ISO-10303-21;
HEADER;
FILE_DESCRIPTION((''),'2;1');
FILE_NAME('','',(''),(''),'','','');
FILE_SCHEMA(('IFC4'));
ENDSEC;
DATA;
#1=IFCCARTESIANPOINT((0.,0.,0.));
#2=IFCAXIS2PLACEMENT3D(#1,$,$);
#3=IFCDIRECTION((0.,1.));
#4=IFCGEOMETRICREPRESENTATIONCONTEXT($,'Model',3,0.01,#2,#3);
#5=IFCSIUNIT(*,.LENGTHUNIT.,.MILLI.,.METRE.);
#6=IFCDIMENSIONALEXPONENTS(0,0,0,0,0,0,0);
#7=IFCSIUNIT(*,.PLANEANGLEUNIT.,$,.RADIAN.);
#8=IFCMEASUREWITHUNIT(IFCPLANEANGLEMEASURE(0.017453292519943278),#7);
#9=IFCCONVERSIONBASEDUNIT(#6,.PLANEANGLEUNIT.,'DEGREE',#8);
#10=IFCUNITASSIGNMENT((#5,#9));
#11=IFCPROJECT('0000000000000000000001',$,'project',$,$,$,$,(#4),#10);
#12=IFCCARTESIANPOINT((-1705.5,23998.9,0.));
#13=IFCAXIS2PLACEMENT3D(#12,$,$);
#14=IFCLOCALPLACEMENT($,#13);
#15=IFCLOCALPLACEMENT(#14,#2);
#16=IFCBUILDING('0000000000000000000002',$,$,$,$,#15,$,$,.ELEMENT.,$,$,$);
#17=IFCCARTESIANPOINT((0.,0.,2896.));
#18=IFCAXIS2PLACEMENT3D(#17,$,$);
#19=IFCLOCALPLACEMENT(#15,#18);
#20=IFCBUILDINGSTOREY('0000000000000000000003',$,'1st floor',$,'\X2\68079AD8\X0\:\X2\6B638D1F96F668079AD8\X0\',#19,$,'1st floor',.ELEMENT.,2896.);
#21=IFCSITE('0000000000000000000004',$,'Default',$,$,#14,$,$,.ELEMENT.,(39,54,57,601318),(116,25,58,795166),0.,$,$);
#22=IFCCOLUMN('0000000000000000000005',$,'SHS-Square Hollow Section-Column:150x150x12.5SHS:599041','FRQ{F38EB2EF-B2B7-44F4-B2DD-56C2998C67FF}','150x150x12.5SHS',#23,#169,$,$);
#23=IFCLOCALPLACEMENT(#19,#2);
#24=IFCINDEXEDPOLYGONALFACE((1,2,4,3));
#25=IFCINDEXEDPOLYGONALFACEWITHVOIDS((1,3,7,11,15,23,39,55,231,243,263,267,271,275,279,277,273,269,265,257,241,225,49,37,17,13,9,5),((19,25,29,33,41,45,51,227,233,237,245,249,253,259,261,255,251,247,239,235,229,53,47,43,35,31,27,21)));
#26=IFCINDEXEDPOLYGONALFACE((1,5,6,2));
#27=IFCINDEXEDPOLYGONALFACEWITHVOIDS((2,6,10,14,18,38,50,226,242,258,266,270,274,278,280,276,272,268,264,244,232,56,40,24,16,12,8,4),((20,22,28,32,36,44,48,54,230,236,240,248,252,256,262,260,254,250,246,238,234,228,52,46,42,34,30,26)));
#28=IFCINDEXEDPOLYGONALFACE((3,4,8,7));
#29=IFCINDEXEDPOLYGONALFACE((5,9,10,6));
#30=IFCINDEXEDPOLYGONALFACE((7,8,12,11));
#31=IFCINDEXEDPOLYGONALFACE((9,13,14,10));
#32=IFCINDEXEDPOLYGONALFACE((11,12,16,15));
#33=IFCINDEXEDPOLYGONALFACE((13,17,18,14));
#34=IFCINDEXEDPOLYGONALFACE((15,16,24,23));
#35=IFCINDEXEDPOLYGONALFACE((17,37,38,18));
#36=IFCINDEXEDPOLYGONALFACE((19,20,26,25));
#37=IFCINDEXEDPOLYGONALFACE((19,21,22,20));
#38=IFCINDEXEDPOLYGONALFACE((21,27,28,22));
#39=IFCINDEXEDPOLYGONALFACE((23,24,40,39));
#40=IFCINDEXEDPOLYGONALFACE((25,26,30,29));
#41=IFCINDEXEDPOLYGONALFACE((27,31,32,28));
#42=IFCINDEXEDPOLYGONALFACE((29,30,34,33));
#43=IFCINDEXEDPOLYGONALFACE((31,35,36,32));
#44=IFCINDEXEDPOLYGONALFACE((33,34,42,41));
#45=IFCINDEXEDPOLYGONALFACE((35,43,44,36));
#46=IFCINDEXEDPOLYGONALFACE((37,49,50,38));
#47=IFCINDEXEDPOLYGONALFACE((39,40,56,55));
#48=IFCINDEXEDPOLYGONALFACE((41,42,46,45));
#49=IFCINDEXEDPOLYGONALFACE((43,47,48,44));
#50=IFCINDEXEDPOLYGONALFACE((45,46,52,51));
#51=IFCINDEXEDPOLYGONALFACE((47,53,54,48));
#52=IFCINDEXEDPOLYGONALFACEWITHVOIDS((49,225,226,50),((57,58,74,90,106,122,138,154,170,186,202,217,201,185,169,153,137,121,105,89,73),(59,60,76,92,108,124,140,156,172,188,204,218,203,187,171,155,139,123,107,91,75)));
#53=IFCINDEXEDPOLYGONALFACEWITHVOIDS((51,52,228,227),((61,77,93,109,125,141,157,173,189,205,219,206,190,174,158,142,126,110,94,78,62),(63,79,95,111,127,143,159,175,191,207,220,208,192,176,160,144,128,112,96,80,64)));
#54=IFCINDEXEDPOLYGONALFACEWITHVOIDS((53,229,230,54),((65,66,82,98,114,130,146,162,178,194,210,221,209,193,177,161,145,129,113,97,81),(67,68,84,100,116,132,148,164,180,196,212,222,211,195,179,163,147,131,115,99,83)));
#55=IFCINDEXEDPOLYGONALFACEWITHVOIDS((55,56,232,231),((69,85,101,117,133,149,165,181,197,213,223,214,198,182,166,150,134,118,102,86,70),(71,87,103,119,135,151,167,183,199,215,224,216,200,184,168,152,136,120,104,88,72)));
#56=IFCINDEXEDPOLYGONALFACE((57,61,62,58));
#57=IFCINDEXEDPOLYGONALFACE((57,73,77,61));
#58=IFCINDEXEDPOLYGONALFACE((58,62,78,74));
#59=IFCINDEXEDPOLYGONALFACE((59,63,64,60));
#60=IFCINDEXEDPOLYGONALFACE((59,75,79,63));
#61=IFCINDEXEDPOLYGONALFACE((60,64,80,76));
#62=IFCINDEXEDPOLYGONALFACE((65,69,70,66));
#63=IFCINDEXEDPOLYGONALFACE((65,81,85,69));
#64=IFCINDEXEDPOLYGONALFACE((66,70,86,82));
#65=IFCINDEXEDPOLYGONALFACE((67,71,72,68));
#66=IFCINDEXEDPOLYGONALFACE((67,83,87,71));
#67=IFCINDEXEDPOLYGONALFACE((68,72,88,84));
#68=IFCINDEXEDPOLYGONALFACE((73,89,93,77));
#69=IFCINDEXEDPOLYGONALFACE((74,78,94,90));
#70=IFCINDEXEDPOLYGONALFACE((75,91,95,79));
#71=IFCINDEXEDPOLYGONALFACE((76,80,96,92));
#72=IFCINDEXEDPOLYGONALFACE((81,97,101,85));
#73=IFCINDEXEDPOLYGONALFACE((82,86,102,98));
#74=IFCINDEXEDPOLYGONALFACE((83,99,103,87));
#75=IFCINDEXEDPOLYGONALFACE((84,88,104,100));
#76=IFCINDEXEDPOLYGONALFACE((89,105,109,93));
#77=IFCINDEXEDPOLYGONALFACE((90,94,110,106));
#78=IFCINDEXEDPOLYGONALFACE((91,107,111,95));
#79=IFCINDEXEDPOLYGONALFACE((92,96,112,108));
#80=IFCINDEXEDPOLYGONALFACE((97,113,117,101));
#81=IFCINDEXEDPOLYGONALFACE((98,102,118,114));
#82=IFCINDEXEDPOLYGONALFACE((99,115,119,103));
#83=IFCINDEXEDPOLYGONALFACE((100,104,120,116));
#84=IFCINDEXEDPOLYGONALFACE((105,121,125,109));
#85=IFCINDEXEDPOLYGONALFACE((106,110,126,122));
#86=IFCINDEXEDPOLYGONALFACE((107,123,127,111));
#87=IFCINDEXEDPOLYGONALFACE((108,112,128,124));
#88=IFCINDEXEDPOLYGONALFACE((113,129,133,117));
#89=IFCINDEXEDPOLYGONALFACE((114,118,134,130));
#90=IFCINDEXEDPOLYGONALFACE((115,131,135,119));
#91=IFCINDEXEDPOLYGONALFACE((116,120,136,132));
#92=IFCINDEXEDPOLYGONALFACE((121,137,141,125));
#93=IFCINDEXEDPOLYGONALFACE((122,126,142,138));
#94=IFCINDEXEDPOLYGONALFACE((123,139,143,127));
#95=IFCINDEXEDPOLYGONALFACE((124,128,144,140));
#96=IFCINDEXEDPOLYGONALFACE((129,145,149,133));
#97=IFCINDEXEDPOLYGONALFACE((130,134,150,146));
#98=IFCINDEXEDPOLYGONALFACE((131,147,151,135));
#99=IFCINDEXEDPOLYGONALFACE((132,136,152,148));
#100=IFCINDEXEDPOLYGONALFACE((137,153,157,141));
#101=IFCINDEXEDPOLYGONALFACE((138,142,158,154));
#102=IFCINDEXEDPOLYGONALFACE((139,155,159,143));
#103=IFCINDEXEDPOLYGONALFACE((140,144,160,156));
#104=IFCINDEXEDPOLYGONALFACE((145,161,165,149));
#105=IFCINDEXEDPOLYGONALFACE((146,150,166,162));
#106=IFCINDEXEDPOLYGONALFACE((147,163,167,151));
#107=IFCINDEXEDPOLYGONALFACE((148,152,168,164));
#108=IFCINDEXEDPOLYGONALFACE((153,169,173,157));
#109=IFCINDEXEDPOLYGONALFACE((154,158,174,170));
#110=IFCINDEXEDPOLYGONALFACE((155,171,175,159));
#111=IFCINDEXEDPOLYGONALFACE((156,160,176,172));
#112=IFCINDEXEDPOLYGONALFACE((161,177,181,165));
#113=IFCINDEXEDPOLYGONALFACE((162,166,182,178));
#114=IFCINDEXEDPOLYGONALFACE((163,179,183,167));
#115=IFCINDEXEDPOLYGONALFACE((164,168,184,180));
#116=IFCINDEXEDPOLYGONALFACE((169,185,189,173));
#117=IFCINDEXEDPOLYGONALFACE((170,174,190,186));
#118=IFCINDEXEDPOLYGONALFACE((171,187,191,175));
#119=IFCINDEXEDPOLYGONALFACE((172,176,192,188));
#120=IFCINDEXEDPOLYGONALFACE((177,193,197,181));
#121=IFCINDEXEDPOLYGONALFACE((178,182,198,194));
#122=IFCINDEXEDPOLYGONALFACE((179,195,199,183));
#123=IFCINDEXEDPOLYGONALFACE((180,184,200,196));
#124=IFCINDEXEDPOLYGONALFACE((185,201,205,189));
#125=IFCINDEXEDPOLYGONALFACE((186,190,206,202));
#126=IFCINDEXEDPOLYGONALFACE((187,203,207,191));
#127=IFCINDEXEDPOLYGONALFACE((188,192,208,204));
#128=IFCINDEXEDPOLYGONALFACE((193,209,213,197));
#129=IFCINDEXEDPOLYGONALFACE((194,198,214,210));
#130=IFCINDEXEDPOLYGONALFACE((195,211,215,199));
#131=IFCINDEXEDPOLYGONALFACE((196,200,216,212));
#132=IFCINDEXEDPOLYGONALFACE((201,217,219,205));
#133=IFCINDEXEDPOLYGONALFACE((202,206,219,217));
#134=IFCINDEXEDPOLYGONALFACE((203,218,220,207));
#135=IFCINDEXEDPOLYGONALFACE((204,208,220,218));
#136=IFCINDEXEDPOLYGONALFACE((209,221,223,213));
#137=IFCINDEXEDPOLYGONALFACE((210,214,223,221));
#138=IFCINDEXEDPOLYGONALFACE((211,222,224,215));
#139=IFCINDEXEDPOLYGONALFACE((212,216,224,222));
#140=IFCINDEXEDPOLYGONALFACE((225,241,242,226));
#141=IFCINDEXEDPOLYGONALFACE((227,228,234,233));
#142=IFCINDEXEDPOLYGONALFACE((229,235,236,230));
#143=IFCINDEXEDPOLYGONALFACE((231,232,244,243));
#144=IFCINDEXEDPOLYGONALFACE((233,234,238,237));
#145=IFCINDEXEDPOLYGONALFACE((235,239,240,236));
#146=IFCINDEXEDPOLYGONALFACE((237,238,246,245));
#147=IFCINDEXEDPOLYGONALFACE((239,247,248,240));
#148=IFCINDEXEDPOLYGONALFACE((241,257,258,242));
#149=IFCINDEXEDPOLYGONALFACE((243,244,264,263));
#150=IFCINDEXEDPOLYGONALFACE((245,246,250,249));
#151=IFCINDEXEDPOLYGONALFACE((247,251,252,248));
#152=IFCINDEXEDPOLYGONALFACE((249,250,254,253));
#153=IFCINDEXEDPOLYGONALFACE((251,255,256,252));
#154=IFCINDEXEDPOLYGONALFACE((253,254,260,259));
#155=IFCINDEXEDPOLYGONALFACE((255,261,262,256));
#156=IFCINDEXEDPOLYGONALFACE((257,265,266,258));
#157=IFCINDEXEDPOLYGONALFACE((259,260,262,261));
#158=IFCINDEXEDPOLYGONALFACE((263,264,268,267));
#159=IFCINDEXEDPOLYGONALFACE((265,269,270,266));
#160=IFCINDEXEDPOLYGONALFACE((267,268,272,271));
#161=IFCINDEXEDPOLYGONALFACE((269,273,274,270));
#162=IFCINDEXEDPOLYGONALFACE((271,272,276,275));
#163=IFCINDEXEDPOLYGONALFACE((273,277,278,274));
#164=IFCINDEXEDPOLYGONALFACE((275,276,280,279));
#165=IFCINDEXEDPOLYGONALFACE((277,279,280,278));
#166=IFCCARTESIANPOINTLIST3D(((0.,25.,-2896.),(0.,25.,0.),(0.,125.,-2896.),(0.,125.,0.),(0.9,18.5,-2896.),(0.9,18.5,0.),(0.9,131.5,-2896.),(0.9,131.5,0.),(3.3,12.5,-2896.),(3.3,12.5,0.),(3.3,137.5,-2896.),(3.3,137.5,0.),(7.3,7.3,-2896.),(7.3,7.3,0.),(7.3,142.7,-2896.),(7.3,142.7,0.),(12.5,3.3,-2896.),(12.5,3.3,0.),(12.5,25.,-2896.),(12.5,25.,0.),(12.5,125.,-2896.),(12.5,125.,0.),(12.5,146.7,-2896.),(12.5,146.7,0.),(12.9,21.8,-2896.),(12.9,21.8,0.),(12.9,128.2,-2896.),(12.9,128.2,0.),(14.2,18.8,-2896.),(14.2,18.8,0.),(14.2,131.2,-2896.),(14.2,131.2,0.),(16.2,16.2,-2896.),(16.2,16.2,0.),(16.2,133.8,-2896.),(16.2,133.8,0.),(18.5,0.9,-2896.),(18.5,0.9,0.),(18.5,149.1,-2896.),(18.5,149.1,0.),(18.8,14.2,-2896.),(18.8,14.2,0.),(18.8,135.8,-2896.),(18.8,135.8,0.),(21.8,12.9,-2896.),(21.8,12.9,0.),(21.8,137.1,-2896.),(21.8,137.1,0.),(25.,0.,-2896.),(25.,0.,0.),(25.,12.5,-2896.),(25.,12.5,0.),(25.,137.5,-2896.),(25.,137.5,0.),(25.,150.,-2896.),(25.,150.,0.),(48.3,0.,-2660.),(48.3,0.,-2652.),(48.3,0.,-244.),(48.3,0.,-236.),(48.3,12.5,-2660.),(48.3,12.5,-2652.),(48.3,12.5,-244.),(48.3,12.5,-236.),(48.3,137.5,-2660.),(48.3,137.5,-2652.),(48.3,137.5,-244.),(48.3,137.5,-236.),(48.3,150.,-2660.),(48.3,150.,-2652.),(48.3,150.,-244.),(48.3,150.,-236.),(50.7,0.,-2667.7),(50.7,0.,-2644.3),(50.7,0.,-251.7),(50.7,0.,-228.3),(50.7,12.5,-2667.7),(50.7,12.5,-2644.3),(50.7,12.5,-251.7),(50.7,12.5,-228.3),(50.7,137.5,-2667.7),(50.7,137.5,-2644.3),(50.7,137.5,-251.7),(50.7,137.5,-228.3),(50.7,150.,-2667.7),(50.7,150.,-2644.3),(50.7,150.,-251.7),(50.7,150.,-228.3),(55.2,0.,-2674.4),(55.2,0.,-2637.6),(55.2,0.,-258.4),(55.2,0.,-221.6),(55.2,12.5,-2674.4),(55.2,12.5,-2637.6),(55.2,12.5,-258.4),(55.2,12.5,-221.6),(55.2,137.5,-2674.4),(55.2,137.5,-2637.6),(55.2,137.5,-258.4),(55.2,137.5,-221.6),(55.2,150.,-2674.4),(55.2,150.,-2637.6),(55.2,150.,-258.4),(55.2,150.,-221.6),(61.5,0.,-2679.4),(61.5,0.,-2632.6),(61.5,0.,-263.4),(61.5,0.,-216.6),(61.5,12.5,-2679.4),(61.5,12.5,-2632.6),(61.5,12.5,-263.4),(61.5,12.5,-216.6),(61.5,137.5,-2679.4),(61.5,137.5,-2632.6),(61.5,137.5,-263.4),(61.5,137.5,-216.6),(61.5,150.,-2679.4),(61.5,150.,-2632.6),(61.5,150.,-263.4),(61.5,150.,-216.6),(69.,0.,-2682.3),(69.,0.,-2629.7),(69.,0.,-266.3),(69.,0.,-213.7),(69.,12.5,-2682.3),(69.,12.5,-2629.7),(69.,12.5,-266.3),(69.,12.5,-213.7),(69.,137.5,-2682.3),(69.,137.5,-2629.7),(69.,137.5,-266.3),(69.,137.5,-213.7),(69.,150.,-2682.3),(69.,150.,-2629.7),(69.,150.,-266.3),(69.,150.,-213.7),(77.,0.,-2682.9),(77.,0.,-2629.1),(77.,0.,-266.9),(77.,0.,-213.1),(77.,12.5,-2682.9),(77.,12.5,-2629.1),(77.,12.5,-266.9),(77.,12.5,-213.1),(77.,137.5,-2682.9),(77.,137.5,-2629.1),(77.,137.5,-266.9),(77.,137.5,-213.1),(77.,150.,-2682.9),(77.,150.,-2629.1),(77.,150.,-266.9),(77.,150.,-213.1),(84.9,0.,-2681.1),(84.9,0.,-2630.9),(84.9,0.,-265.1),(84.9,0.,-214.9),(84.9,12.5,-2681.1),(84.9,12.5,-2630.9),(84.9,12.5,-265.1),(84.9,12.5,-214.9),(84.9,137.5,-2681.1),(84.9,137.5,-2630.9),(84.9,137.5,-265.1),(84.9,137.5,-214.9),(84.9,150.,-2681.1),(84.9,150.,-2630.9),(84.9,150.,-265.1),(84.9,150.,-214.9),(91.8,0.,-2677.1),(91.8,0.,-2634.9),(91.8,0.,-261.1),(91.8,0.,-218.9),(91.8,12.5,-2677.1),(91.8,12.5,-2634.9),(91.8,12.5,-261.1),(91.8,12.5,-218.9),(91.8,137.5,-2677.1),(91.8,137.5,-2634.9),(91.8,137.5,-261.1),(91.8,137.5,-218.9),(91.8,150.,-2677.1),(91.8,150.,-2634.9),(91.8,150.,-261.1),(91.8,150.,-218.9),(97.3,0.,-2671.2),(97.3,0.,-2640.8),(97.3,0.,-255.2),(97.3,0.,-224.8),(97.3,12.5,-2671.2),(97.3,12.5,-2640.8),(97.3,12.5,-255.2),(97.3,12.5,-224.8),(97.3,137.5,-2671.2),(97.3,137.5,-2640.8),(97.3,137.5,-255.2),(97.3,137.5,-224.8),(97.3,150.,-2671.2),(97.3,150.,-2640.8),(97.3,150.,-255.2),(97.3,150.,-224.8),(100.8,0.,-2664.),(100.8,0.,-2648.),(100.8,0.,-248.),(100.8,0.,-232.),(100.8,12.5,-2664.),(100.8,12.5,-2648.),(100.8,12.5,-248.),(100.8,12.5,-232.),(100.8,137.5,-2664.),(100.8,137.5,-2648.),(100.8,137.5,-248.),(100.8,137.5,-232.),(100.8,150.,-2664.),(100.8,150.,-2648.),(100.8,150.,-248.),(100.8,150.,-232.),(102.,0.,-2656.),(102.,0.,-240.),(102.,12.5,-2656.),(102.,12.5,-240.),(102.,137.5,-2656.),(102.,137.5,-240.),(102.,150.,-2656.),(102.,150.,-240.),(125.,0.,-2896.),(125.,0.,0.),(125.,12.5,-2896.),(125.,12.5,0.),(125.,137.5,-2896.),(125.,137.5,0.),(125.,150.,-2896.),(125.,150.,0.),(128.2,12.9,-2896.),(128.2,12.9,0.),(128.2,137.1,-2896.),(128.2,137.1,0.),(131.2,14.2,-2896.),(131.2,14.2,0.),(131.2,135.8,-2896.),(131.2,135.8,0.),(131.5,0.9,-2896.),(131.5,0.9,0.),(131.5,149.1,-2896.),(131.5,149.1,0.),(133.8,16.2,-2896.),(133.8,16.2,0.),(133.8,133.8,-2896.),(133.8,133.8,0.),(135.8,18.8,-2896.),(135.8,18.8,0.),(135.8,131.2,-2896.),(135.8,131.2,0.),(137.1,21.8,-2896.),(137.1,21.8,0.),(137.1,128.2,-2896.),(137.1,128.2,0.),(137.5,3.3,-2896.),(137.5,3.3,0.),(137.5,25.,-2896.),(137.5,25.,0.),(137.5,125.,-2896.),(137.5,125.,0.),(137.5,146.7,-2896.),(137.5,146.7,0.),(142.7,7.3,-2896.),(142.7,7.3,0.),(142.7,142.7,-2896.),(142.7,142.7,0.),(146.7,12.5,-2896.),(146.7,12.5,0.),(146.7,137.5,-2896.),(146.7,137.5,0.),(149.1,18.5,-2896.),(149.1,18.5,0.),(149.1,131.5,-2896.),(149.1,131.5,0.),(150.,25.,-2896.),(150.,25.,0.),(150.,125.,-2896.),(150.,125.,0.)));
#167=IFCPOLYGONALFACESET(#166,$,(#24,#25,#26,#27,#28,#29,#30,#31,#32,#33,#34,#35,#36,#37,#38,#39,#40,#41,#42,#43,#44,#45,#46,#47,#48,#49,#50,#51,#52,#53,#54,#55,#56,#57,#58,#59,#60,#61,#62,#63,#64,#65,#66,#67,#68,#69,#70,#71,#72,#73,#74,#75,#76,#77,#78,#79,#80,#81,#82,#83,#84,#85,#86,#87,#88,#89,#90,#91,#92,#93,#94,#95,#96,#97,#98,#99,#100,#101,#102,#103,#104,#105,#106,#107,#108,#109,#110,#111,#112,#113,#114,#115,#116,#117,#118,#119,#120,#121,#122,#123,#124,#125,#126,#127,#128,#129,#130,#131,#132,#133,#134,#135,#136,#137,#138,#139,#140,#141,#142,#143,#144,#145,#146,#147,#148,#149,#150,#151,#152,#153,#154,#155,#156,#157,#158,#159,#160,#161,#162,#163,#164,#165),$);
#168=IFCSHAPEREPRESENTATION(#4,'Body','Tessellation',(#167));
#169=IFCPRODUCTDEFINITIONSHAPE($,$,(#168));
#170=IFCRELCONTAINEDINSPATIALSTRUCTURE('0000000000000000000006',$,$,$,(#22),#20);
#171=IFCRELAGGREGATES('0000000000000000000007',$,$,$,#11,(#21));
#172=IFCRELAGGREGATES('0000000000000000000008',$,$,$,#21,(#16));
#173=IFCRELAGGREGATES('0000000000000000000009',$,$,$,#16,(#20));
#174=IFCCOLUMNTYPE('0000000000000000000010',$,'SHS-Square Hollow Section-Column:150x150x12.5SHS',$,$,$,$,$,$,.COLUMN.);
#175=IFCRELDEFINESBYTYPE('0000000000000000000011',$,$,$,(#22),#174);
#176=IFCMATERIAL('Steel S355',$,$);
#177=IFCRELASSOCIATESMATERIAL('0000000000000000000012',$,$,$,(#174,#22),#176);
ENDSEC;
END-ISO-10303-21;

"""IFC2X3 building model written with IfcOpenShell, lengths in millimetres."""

from ifc_helpers import new_model, entity, si_unit, converted_unit, direction, frame, frame_2d, origin, origin_2d, place, context, project, spatial, circle_curve, hollow_rectangle, outline, extrude, material, type_object, element, save


model = new_model("IFC2X3")

# Units and contexts
model_context = context("Model", 3, precision=0.01, world=origin(), true_north=direction((0.0, 1.0)))
ifc_project = project(units=[si_unit("LENGTHUNIT", "METRE", prefix="MILLI"), converted_unit("PLANEANGLEUNIT", "DEGREE", entity("IfcPlaneAngleMeasure", 0.017453292519943278), si_unit("PLANEANGLEUNIT", "RADIAN"), dimensions=[0, 0, 0, 0, 0, 0, 0])], contexts=[model_context])

# Site, building, storey
site_placement = place(None, frame((-1705.5, 23998.9, 0.0)))
site = spatial("IfcSite", under=ifc_project, at=site_placement, Name="Default", CompositionType="ELEMENT", RefLatitude=(39, 54, 57, 601318), RefLongitude=(116, 25, 58, 795166), RefElevation=0.0)
building_placement = place(site_placement, origin())
building = spatial("IfcBuilding", under=site, at=building_placement, CompositionType="ELEMENT")
storey_placement = place(building_placement, frame((0.0, 0.0, 2896.0)))
storey = spatial("IfcBuildingStorey", under=building, at=storey_placement, Name="1st floor", ObjectType="标高:正负零标高", LongName="1st floor", CompositionType="ELEMENT", Elevation=2896.0)

# Shared definitions
ifc_material_1 = material(Name="Steel S355")

# Column, openings
column_type_1 = type_object("IfcColumnType", Name="SHS-Square Hollow Section-Column:150x150x12.5SHS", PredefinedType="COLUMN", material=ifc_material_1)
column_1_placement = place(storey_placement, frame((75.0, 75.0, 0.0), z_axis=(0.0, 0.0, 1.0), x_axis=(0.0, -1.0, 0.0)))
column_1 = element("IfcColumn", 1, at=column_1_placement, inside=storey, type_object=column_type_1, material=ifc_material_1, Name="SHS-Square Hollow Section-Column:150x150x12.5SHS:599041", Description="FRQ{F38EB2EF-B2B7-44F4-B2DD-56C2998C67FF}", ObjectType="150x150x12.5SHS", context=model_context, shape_type="SweptSolid", body=[
    extrude(hollow_rectangle(XDim=150.0, YDim=150.0, WallThickness=12.5, InnerFilletRadius=12.5, OuterFilletRadius=25.0, at=origin_2d()), origin(), (0.0, 0.0, -1.0), 2896.0),
])
opening_1_placement = place(column_1_placement, frame((-175.1, 0.0, -2896.0), z_axis=(1.0, 0.0, 0.0), x_axis=(0.0, 1.0, 0.0)))
element("IfcOpeningElement", 2, at=opening_1_placement, cuts=column_1, ObjectType="Opening", context=model_context, shape_type="SweptSolid", body=[
    extrude(outline(circle_curve(frame_2d((0.0, 240.0), x_axis=(1.0, 0.0)), 27.0)), origin(), (0.0, 0.0, 1.0), 350.2),
])
opening_2_placement = place(column_1_placement, frame((-175.1, 0.0, 0.0), z_axis=(1.0, 0.0, 0.0), x_axis=(0.0, 1.0, 0.0)))
element("IfcOpeningElement", 3, at=opening_2_placement, cuts=column_1, ObjectType="Opening", context=model_context, shape_type="SweptSolid", body=[
    extrude(outline(circle_curve(frame_2d((0.0, -240.0), x_axis=(1.0, 0.0)), 27.0)), origin(), (0.0, 0.0, 1.0), 350.2),
])

save(model, "model.ifc")
